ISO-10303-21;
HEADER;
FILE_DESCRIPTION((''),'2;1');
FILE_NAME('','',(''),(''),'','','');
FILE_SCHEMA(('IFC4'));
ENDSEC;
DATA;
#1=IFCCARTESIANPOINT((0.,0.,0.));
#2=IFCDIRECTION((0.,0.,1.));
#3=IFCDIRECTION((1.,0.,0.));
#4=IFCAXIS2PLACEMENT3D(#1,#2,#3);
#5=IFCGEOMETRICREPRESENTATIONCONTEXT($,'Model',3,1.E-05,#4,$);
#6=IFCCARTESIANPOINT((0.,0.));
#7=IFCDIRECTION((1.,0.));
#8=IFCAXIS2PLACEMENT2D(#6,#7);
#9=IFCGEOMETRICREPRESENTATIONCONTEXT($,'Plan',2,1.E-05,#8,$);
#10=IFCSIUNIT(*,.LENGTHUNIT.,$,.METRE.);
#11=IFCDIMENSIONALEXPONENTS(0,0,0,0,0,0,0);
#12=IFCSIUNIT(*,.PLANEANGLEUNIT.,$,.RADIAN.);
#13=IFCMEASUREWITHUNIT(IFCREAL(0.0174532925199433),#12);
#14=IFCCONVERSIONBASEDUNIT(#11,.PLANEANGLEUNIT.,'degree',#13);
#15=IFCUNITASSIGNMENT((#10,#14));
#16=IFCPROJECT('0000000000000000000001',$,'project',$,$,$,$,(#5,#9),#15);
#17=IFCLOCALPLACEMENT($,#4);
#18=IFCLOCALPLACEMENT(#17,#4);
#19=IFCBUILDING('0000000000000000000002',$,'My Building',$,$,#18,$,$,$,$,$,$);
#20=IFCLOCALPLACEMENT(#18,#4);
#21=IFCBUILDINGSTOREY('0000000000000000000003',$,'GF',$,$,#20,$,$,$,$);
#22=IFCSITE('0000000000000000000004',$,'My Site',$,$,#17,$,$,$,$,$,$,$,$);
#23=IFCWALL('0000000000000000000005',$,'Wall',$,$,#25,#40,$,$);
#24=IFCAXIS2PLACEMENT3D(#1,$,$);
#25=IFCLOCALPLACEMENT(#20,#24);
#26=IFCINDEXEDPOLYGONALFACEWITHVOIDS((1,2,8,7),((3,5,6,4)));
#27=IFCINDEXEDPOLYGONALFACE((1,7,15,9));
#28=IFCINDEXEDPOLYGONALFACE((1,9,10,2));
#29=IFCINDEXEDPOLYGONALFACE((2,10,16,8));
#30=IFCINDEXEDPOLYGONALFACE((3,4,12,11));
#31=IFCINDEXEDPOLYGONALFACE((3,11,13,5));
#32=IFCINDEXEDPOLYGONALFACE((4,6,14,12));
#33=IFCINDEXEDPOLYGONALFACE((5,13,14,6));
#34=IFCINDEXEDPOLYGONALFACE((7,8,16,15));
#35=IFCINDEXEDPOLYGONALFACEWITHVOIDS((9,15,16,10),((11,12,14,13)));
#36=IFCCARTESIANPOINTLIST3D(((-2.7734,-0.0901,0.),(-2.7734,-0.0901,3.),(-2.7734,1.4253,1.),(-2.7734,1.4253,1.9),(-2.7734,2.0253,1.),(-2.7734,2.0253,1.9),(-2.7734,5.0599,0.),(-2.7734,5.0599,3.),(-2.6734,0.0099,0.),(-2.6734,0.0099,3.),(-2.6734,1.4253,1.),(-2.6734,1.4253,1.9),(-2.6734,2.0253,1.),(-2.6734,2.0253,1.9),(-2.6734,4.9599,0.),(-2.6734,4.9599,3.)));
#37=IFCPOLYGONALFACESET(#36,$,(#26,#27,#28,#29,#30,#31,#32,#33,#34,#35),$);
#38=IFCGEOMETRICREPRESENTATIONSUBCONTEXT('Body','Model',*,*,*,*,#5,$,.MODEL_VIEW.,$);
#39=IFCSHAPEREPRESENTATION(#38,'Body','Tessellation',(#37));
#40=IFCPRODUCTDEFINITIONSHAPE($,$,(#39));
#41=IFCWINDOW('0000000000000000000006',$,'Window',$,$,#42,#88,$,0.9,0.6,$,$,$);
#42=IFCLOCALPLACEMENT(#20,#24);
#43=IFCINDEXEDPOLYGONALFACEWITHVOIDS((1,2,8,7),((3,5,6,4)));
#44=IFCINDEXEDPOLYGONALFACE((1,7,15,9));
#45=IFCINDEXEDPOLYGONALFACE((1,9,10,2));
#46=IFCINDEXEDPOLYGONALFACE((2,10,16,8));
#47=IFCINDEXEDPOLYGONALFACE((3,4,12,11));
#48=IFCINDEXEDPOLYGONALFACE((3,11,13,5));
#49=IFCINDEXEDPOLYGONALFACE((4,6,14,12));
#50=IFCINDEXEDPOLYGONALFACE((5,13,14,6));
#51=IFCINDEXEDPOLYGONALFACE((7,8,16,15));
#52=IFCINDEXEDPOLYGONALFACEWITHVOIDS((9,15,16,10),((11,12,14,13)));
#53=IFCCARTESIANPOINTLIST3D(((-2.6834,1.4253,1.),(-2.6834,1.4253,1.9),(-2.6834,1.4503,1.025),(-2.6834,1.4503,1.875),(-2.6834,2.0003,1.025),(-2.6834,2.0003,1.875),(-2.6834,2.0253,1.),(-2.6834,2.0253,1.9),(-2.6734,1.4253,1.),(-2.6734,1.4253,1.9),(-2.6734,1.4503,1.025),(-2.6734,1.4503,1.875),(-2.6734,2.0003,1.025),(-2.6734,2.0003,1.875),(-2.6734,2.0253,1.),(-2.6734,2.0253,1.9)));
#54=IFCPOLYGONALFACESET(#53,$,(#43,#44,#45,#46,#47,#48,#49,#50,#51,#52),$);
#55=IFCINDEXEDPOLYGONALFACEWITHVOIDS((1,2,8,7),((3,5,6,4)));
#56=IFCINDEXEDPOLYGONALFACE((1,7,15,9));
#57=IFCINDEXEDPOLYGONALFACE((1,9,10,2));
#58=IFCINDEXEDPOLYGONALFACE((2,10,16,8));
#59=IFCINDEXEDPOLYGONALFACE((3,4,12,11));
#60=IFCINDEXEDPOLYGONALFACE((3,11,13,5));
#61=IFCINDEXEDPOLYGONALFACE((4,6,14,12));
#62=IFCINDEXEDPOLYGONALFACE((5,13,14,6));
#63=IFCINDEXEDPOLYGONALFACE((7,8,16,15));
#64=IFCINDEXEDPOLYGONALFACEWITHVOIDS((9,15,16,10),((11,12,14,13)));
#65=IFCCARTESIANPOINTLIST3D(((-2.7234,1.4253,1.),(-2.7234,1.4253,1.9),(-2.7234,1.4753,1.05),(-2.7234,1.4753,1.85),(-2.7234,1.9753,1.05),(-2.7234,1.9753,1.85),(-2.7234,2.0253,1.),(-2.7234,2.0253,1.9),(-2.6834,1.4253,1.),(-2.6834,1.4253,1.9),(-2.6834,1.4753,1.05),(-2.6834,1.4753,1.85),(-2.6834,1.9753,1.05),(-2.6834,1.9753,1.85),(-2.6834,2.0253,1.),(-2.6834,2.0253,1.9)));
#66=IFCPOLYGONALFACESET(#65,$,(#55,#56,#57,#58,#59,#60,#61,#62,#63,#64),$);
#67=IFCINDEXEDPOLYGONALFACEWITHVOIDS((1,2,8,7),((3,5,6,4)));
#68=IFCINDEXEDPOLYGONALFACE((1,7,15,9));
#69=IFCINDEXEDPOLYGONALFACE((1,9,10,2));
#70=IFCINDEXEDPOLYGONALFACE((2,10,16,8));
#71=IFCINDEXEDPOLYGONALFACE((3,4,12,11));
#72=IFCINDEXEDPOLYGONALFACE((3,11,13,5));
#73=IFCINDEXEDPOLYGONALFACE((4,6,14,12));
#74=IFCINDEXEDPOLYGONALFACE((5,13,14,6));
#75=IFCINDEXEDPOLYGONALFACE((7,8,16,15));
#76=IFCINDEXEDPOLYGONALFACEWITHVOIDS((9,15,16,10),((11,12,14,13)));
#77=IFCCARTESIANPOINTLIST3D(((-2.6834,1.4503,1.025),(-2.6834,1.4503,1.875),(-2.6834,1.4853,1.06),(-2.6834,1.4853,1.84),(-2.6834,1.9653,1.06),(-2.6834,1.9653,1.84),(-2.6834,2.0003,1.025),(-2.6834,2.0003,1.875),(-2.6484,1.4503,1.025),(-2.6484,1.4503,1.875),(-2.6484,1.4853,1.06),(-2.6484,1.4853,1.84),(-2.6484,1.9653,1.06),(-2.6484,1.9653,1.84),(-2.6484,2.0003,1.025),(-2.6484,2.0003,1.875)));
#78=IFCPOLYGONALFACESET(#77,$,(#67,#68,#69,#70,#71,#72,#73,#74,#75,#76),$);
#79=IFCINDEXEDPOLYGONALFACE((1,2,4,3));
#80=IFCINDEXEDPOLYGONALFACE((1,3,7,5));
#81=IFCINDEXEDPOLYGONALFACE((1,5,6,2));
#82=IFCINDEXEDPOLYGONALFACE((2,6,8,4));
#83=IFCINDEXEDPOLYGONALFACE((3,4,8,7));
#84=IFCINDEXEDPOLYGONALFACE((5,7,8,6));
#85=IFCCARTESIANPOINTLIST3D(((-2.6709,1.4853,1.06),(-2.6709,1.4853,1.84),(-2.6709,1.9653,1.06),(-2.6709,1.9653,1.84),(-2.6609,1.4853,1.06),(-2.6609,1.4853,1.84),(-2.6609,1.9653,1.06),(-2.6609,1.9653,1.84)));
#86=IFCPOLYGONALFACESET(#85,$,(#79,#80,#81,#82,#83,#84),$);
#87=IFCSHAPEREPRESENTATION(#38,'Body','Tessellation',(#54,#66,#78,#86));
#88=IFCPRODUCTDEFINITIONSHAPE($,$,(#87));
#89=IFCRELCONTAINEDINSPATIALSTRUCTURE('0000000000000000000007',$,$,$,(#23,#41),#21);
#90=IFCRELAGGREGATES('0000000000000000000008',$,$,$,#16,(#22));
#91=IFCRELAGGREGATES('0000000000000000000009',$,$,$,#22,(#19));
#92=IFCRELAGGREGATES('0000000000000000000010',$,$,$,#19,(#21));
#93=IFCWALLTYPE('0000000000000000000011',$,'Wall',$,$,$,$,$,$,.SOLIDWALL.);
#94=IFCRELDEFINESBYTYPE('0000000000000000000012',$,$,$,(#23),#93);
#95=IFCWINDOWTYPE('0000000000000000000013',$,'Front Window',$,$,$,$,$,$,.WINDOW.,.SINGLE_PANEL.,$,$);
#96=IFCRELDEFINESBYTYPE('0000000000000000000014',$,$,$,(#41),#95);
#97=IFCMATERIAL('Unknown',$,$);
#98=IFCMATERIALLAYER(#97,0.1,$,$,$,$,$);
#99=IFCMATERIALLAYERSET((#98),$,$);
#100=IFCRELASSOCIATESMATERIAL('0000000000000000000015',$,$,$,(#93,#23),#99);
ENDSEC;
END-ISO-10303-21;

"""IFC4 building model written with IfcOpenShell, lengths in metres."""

from ifc_helpers import new_model, entity, si_unit, converted_unit, frame, origin_with_axes, origin_2d_with_axis, place, context, subcontext, project, spatial, line, indexed_curve, outline, extrude, shape, source, transform, mapped, material, layer, layer_set, layer_usage, type_object, type_shapes, element, fill, save


model = new_model("IFC4")

# Units and contexts
model_context = context("Model", 3, precision=1e-05, world=origin_with_axes())
plan_context = context("Plan", 2, precision=1e-05, world=origin_2d_with_axis())
body_context_1 = subcontext(model_context, "Body", "Model", "MODEL_VIEW")
body_context_2 = subcontext(plan_context, "Body", "Plan", "PLAN_VIEW")
ifc_project = project(units=[si_unit("LENGTHUNIT", "METRE"), converted_unit("PLANEANGLEUNIT", "degree", entity("IfcReal", 0.0174532925199433), si_unit("PLANEANGLEUNIT", "RADIAN"), dimensions=[0, 0, 0, 0, 0, 0, 0])], contexts=[model_context, plan_context])

# Site, building, storey
site_placement = place(None, origin_with_axes())
site = spatial("IfcSite", under=ifc_project, at=site_placement, Name="My Site")
building_placement = place(site_placement, origin_with_axes())
building = spatial("IfcBuilding", under=site, at=building_placement, Name="My Building")
storey_placement = place(building_placement, origin_with_axes())
storey = spatial("IfcBuildingStorey", under=building, at=storey_placement, Name="GF")

# Shared definitions
ifc_material = material(Name="Unknown")

# Shared definitions
ifc_layer_1 = layer(ifc_material, 0.1)
ifc_layer_set_1 = layer_set([ifc_layer_1])
wall_type = type_object("IfcWallType", Name="Wall", PredefinedType="SOLIDWALL", material=ifc_layer_set_1)

# Wall, opening, window
ifc_layer_usage_1 = layer_usage(ifc_layer_set_1, "AXIS2", "POSITIVE", 0.0)
wall_1_placement = place(storey_placement, frame((-2.7734, 5.0599, 0.0), z_axis=(0.0, 0.0, 1.0), x_axis=(0.0, -1.0, 0.0)))
wall_1 = element("IfcWall", 1, at=wall_1_placement, inside=storey, type_object=wall_type, material=ifc_layer_usage_1, Name="Wall", context=body_context_1, shape_type="SweptSolid", body=[
    extrude(outline(indexed_curve([(0.0, 0.0), (0.1, 0.1), (5.05, 0.1), (5.15, 0.0)], segments=[line(1, 2, 3, 4, 1)])), origin_with_axes(), (0.0, 0.0, 1.0), 3.0),
])
shared_shape_1 = source(origin_with_axes(), body_context_1, "Body", "SweptSolid", [
    extrude(outline(indexed_curve([(0.0, 0.0), (0.6, 0.0), (0.6, 0.9), (0.0, 0.9)], segments=[line(1, 2, 3, 4, 1)])), frame((0.0, -0.6, 0.0), z_axis=(0.0, -1.0, 0.0), x_axis=(1.0, 0.0, 0.0)), (0.0, 0.0, -1.0), 1.2),
])
opening_1_placement = place(wall_1_placement, frame((3.0346, 0.0, 1.0), z_axis=(0.0, 0.0, 1.0), x_axis=(1.0, 0.0, 0.0)))
opening_1 = element("IfcOpeningElement", 2, at=opening_1_placement, cuts=wall_1, PredefinedType="OPENING", context=body_context_1, shape_type="MappedRepresentation", body=[
    mapped(shared_shape_1, transform((0.0, 0.0, 0.0), x_axis=(1.0, 0.0, 0.0), y_axis=(0.0, 1.0, 0.0), z_axis=(0.0, 0.0, 1.0), scale=1.0)),
])
window_type_1 = type_object("IfcWindowType", Name="Front Window", PartitioningType="SINGLE_PANEL", PredefinedType="WINDOW")
shared_shape_2 = source(origin_with_axes(), body_context_1, "Body", "SweptSolid", [
    extrude(outline(indexed_curve([(0.0, 0.0), (0.6, 0.0), (0.6, 0.9), (0.0, 0.9)], segments=[line(1, 2, 3, 4, 1)]), holes=[indexed_curve([(0.025, 0.025), (0.575, 0.025), (0.575, 0.875), (0.025, 0.875)], segments=[line(1, 2, 3, 4, 1)])]), frame((0.0, 0.09, 0.0), z_axis=(0.0, -1.0, 0.0), x_axis=(1.0, 0.0, 0.0)), (0.0, 0.0, -1.0), 0.01),
    extrude(outline(indexed_curve([(0.0, 0.0), (0.6, 0.0), (0.6, 0.9), (0.0, 0.9)], segments=[line(1, 2, 3, 4, 1)]), holes=[indexed_curve([(0.05, 0.05), (0.55, 0.05), (0.55, 0.85), (0.05, 0.85)], segments=[line(1, 2, 3, 4, 1)])]), frame((0.0, 0.05, 0.0), z_axis=(0.0, -1.0, 0.0), x_axis=(1.0, 0.0, 0.0)), (0.0, 0.0, -1.0), 0.04),
    extrude(outline(indexed_curve([(0.0, 0.0), (0.55, 0.0), (0.55, 0.85), (0.0, 0.85)], segments=[line(1, 2, 3, 4, 1)]), holes=[indexed_curve([(0.035, 0.035), (0.515, 0.035), (0.515, 0.815), (0.035, 0.815)], segments=[line(1, 2, 3, 4, 1)])]), frame((0.025, 0.09, 0.025), z_axis=(0.0, -1.0, 0.0), x_axis=(1.0, 0.0, 0.0)), (0.0, 0.0, -1.0), 0.035),
    extrude(outline(indexed_curve([(0.035, 0.035), (0.515, 0.035), (0.515, 0.815), (0.035, 0.815)], segments=[line(1, 2, 3, 4, 1)])), frame((0.025, 0.1025, 0.025), z_axis=(0.0, -1.0, 0.0), x_axis=(1.0, 0.0, 0.0)), (0.0, 0.0, -1.0), 0.01),
])
shared_shape_3 = source(origin_with_axes(), body_context_2, "Body", "Curve2D", [
    entity("IfcIndexedPolyCurve", entity("IfcCartesianPointList2D", [[0.05, 0.05], [0.55, 0.05]])),
    entity("IfcIndexedPolyCurve", entity("IfcCartesianPointList2D", [[0.0, 0.1], [0.025, 0.1], [0.025, 0.09], [0.05, 0.09], [0.05, 0.05], [0.0, 0.05]]), [entity("IfcLineIndex", [1, 2, 3, 4, 5, 6, 1])]),
    entity("IfcIndexedPolyCurve", entity("IfcCartesianPointList2D", [[0.6, 0.1], [0.575, 0.1], [0.575, 0.09], [0.55, 0.09], [0.55, 0.05], [0.6, 0.05]]), [entity("IfcLineIndex", [1, 2, 3, 4, 5, 6, 1])]),
    entity("IfcIndexedPolyCurve", entity("IfcCartesianPointList2D", [[0.025, 0.09], [0.06, 0.09], [0.06, 0.125], [0.025, 0.125]]), [entity("IfcLineIndex", [1, 2, 3, 4, 1])]),
    entity("IfcIndexedPolyCurve", entity("IfcCartesianPointList2D", [[0.575, 0.09], [0.54, 0.09], [0.54, 0.125], [0.575, 0.125]]), [entity("IfcLineIndex", [1, 2, 3, 4, 1])]),
    entity("IfcIndexedPolyCurve", entity("IfcCartesianPointList2D", [[0.06, 0.09], [0.54, 0.09]])),
    entity("IfcIndexedPolyCurve", entity("IfcCartesianPointList2D", [[0.06, 0.125], [0.54, 0.125]])),
    entity("IfcIndexedPolyCurve", entity("IfcCartesianPointList2D", [[0.06, 0.1075], [0.54, 0.1075]])),
])
type_shapes(window_type_1, [shared_shape_2, shared_shape_3])
window_1_placement = place(opening_1_placement, frame((0.0, 0.0, 0.0), z_axis=(0.0, 0.0, 1.0), x_axis=(1.0, 0.0, 0.0)))
window_1 = element("IfcWindow", 3, at=window_1_placement, inside=storey, type_object=window_type_1, Name="Window", OverallHeight=0.9, OverallWidth=0.6, shapes=[
    shape(body_context_1, "Body", "MappedRepresentation", [mapped(shared_shape_2, transform((0.0, 0.0, 0.0), x_axis=(1.0, 0.0, 0.0), y_axis=(0.0, 1.0, 0.0), z_axis=(0.0, 0.0, 1.0), scale=1.0))]),
    shape(body_context_2, "Body", "MappedRepresentation", [mapped(shared_shape_3, transform((0.0, 0.0, 0.0), x_axis=(1.0, 0.0, 0.0), y_axis=(0.0, 1.0, 0.0), z_axis=(0.0, 0.0, 1.0), scale=1.0))]),
])
fill(opening_1, window_1)

save(model, "model.ifc")
